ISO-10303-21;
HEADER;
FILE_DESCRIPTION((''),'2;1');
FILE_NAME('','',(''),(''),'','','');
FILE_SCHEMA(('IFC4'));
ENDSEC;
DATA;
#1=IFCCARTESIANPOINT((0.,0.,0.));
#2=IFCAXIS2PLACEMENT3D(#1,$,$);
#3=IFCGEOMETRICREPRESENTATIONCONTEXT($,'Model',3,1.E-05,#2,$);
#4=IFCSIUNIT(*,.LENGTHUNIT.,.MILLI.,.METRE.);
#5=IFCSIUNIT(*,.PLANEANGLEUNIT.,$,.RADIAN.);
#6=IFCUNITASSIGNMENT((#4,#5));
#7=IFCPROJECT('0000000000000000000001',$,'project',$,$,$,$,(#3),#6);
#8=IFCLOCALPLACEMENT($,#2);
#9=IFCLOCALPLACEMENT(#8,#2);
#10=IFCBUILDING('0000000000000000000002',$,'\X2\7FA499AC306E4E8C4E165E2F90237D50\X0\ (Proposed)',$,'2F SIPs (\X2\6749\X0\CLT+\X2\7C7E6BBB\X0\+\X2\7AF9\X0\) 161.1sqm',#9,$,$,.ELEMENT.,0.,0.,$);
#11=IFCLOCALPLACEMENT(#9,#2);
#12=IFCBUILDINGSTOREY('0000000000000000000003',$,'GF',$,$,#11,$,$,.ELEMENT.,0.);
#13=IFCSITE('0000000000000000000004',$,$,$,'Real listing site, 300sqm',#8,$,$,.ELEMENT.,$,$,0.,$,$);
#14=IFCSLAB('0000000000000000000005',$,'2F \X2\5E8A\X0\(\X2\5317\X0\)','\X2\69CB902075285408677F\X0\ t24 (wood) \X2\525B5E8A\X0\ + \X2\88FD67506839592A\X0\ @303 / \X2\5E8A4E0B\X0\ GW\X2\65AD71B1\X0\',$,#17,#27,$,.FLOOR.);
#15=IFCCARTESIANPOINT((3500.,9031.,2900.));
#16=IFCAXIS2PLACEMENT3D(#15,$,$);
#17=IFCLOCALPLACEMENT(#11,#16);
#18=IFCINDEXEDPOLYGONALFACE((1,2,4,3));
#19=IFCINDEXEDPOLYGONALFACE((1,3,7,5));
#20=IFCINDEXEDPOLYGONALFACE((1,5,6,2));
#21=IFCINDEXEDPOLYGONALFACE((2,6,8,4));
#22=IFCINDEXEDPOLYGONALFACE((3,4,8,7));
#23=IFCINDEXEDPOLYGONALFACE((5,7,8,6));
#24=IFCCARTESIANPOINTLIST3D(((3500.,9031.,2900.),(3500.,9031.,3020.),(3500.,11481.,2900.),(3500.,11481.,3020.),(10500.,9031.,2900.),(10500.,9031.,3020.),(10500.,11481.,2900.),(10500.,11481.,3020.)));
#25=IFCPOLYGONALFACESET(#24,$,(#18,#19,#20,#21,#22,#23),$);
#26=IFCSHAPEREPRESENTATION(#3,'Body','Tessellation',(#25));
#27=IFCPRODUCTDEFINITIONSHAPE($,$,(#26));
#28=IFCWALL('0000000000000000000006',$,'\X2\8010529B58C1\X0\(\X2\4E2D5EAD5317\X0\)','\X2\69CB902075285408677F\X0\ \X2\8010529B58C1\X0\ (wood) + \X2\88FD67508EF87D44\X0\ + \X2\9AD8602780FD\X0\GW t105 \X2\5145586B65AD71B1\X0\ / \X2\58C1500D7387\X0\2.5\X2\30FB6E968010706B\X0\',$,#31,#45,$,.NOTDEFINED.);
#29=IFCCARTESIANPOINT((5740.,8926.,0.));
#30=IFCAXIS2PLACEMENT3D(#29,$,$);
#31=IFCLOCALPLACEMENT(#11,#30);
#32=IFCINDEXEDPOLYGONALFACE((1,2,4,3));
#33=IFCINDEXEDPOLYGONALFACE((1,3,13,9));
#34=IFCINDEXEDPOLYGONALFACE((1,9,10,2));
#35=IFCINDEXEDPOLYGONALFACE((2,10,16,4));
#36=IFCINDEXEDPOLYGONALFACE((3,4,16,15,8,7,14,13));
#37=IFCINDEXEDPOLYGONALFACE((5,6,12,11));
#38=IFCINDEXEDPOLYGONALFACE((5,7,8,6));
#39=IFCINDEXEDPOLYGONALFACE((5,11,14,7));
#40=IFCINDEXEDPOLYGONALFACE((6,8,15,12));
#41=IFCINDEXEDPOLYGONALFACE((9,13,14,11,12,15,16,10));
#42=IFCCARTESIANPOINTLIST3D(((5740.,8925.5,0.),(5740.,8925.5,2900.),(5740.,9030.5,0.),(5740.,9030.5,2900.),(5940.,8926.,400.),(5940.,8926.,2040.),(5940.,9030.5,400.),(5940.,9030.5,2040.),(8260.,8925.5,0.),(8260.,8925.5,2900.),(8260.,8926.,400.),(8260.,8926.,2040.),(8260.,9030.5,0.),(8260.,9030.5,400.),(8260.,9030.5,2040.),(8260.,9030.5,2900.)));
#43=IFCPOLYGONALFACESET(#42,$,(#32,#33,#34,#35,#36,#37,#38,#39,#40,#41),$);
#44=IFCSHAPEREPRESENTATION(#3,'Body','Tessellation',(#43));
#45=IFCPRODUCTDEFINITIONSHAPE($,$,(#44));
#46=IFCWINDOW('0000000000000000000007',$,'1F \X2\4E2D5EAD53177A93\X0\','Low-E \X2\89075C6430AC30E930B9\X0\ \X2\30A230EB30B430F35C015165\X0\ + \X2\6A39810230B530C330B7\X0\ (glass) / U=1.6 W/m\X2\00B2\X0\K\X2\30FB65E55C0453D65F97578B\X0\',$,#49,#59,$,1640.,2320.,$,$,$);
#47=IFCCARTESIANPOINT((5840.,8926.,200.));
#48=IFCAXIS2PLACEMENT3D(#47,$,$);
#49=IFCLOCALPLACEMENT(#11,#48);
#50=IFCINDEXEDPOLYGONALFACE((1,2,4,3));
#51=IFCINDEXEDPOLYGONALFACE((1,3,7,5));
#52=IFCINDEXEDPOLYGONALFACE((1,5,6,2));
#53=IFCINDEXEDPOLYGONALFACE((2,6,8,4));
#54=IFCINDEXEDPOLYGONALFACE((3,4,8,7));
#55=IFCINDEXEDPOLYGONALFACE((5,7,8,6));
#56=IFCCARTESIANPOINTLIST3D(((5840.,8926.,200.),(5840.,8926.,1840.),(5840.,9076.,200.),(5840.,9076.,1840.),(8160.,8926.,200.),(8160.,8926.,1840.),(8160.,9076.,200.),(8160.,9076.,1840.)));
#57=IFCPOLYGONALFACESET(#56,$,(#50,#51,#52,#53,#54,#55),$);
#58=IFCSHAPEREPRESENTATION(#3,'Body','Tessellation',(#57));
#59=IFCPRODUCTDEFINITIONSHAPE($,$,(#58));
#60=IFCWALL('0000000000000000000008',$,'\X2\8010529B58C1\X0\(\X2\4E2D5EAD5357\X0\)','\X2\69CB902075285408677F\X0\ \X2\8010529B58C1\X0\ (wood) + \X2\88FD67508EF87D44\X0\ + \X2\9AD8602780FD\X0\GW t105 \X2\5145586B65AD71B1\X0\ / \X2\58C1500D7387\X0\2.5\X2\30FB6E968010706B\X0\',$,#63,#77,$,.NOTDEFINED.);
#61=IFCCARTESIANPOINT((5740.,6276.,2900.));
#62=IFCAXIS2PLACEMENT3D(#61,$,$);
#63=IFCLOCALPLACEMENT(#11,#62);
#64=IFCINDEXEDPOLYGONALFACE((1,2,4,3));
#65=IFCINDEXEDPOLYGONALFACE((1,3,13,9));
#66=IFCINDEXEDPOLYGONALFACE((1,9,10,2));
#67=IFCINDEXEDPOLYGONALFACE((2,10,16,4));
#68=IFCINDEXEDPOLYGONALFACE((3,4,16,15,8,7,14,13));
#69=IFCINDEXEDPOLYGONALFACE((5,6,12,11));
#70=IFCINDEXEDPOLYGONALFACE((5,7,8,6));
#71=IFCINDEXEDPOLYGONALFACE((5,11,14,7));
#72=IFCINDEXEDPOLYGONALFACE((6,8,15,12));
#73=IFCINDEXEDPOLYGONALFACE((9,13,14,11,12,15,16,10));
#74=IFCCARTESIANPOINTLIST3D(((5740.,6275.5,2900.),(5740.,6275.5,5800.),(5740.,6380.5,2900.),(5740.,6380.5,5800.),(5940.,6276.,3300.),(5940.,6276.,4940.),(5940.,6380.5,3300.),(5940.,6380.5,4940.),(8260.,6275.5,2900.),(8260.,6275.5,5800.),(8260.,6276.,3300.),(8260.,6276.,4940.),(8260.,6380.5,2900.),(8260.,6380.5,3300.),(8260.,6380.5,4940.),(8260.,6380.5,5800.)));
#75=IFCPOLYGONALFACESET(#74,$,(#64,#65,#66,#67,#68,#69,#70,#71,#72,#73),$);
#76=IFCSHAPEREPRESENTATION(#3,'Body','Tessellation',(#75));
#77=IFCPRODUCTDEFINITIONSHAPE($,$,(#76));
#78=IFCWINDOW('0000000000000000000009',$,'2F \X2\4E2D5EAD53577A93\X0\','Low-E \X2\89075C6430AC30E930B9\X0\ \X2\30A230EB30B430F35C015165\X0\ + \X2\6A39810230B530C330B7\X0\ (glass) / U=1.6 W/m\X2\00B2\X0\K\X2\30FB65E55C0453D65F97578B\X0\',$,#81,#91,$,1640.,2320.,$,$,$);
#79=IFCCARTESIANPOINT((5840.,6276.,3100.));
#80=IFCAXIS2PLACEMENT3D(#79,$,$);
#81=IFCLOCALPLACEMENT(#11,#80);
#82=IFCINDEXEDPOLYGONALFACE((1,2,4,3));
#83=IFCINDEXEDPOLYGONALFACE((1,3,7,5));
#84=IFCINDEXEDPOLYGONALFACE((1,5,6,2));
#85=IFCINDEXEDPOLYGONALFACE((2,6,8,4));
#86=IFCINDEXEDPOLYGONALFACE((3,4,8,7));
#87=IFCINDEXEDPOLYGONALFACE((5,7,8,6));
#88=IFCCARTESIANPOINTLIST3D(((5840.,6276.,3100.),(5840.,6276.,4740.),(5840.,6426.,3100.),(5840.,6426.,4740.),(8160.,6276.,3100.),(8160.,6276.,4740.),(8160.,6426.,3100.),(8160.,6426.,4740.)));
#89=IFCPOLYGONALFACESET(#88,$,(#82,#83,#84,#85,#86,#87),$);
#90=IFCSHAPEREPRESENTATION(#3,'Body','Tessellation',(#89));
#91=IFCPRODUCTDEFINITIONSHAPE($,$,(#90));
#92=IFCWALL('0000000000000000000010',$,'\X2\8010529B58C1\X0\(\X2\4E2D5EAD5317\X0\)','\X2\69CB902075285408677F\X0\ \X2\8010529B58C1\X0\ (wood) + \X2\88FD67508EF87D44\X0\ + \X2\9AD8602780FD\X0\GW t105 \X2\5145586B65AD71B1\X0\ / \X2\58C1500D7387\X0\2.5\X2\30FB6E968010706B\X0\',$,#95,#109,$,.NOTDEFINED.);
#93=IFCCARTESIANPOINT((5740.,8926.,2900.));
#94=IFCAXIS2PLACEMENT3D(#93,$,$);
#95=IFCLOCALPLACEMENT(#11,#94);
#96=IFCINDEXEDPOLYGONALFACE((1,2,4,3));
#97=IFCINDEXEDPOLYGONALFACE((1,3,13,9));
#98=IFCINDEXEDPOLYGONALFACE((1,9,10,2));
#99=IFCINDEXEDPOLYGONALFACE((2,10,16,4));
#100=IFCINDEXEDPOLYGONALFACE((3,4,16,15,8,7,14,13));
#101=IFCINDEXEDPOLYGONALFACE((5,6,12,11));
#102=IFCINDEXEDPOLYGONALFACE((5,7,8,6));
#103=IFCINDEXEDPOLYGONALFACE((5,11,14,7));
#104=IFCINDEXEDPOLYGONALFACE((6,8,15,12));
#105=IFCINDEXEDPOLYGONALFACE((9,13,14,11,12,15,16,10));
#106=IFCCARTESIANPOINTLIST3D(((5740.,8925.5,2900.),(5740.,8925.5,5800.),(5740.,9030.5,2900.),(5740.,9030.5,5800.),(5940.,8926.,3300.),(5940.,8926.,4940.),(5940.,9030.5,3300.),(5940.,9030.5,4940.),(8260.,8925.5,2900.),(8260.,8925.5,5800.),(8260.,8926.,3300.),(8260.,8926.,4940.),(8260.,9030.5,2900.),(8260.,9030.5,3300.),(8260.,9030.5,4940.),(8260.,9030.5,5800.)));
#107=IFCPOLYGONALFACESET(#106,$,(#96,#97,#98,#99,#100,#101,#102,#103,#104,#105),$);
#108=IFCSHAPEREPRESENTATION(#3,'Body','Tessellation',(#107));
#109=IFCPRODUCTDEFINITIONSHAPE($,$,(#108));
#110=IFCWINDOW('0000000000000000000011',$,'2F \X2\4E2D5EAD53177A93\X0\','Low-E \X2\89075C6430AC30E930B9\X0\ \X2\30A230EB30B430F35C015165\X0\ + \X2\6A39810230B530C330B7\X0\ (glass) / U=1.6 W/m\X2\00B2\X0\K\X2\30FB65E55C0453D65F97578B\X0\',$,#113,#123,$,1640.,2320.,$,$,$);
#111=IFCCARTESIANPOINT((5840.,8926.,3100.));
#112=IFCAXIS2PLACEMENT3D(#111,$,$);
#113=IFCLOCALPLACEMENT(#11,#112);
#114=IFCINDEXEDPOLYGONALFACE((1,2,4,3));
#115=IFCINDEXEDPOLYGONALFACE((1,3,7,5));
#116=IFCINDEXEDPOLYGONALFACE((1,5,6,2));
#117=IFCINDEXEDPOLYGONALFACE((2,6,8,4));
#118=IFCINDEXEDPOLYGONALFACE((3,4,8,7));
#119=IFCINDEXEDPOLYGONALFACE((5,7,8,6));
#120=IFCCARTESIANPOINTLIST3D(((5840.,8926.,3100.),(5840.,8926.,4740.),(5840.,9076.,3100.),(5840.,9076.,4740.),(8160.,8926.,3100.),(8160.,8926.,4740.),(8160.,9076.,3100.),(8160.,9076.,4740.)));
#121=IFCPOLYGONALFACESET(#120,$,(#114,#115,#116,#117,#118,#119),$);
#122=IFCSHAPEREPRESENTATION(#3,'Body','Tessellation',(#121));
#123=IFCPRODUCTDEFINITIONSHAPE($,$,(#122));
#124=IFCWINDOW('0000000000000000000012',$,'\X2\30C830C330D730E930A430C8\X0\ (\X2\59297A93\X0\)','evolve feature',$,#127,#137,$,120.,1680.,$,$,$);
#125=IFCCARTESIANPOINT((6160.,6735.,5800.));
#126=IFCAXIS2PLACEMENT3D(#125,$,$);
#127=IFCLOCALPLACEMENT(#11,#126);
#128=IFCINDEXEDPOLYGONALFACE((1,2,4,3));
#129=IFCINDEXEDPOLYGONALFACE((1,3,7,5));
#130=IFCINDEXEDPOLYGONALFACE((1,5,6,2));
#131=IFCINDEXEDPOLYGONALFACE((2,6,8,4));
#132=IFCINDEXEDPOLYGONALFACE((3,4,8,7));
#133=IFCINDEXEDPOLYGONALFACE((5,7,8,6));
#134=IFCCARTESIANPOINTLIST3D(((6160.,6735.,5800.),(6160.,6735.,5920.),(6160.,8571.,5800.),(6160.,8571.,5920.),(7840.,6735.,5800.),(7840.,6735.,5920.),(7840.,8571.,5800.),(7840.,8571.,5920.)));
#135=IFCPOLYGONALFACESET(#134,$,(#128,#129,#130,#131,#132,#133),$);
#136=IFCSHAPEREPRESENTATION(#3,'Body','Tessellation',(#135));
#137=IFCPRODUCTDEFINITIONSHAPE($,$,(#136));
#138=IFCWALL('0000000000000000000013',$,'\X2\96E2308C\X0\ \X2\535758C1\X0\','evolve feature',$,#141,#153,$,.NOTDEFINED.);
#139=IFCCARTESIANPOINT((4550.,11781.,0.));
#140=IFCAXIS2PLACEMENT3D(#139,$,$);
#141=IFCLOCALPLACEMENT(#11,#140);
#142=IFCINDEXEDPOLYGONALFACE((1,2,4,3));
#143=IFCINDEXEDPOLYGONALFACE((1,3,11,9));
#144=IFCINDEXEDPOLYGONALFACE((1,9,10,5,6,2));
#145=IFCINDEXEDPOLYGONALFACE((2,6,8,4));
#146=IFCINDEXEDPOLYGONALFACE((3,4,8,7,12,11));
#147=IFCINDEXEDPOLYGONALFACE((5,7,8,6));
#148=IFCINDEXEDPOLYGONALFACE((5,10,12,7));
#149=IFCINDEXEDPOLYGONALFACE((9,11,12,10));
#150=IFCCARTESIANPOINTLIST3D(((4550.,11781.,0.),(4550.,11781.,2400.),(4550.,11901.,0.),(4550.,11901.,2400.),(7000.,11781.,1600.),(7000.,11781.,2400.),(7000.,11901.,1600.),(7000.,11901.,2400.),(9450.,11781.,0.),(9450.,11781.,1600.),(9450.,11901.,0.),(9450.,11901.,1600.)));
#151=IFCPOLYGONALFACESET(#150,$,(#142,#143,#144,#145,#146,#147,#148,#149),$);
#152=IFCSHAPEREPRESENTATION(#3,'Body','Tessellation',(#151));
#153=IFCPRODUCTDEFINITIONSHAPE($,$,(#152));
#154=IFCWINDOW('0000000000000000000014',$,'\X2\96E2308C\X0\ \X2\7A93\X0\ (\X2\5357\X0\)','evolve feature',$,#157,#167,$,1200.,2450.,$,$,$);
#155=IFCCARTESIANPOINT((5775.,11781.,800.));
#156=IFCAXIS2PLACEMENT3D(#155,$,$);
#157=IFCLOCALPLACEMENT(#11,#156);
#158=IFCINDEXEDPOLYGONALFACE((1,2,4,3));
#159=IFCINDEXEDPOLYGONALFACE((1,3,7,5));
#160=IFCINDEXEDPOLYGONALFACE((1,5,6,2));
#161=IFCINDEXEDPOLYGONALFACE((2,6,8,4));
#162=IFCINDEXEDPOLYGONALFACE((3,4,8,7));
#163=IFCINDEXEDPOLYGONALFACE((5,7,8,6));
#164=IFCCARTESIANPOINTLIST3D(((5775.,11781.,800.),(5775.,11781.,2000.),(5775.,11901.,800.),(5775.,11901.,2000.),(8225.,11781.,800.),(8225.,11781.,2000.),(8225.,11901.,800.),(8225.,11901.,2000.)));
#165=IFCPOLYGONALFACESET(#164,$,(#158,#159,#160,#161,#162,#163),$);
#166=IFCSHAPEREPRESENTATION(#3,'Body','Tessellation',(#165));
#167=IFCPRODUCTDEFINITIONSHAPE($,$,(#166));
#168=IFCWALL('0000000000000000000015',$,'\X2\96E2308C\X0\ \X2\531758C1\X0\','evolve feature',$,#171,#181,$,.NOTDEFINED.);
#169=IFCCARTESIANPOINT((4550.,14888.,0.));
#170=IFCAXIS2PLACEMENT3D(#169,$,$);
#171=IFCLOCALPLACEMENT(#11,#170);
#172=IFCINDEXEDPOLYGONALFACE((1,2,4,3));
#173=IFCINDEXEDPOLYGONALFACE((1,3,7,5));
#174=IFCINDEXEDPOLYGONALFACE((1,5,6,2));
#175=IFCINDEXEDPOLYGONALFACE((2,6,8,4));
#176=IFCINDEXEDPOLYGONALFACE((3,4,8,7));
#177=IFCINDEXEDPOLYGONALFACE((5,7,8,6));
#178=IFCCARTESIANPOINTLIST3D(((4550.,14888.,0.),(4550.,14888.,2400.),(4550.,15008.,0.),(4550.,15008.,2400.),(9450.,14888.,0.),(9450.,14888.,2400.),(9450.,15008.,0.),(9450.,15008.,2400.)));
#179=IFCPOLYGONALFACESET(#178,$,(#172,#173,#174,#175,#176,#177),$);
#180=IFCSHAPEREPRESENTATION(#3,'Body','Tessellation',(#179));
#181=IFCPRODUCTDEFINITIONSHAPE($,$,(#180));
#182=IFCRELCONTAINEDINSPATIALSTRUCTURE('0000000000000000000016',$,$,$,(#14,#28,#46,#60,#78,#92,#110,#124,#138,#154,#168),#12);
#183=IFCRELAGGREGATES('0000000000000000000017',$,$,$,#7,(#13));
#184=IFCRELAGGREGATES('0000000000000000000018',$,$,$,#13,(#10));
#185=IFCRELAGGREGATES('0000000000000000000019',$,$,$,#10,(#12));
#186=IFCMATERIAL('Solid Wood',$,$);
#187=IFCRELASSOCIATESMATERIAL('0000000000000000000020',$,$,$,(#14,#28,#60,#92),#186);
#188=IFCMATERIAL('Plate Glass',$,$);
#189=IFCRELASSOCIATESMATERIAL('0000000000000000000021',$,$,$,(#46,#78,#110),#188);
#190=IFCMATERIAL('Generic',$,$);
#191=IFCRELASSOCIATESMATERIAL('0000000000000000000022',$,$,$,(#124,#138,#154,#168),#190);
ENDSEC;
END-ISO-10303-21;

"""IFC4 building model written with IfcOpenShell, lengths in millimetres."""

from ifc_helpers import new_model, si_unit, frame, frame_2d, origin, place, context, project, spatial, rectangle, extrude, material, element, fill, save


model = new_model("IFC4")

# Units and contexts
model_context = context("Model", 3, precision=1e-05, world=origin())
ifc_project = project(units=[si_unit("LENGTHUNIT", "METRE", prefix="MILLI"), si_unit("PLANEANGLEUNIT", "RADIAN")], contexts=[model_context])

# Site, building, storey
site_placement = place(None, origin())
site = spatial("IfcSite", under=ifc_project, at=site_placement, ObjectType="Real listing site, 300sqm", CompositionType="ELEMENT", RefElevation=0.0)
building_placement = place(site_placement, origin())
building = spatial("IfcBuilding", under=site, at=building_placement, Name="群馬の二世帯連結 (Proposed)", ObjectType="2F SIPs (杉CLT+籾殻+竹) 161.1sqm", CompositionType="ELEMENT", ElevationOfRefHeight=0.0, ElevationOfTerrain=0.0)
storey_placement = place(building_placement, origin())
storey = spatial("IfcBuildingStorey", under=building, at=storey_placement, Name="GF", CompositionType="ELEMENT", Elevation=0.0)

# Slab
ifc_material_1 = material(Name="Solid Wood")
slab_1_placement = place(storey_placement, frame((3500.0, 9031.0, 2900.0)))
element("IfcSlab", 1, at=slab_1_placement, inside=storey, material=ifc_material_1, Name="2F 床(北)", Description="構造用合板 t24 (wood) 剛床 + 製材根太 @303 / 床下 GW断熱", PredefinedType="FLOOR", context=model_context, shape_type="SweptSolid", body=[
    extrude(rectangle(XDim=7000.0, YDim=2450.0, at=frame_2d((3500.0, 1225.0))), frame((3500.0, 9031.0, 2900.0)), (0.0, 0.0, 1.0), 120.0),
])
ifc_material_2 = material(Name="Generic")

# Wall, opening, window
wall_1_placement = place(storey_placement, frame((5740.0, 8926.0, 0.0)))
wall_1 = element("IfcWall", 2, at=wall_1_placement, inside=storey, material=ifc_material_1, Name="耐力壁(中庭北)", Description="構造用合板 耐力壁 (wood) + 製材軸組 + 高性能GW t105 充填断熱 / 壁倍率2.5・準耐火", PredefinedType="NOTDEFINED", context=model_context, shape_type="SweptSolid", body=[
    extrude(rectangle(XDim=2520.0, YDim=105.0, at=frame_2d((1260.0, 52.0))), frame((5740.0, 8926.0, 0.0)), (0.0, 0.0, 1.0), 2900.0),
])
opening_1_placement = place(storey_placement, frame((5840.0, 8926.0, 200.0)))
opening_1 = element("IfcOpeningElement", 3, at=opening_1_placement, cuts=wall_1, PredefinedType="NOTDEFINED", context=model_context, shape_type="SweptSolid", body=[
    extrude(rectangle(XDim=2320.0, YDim=150.0, at=frame_2d((1160.0, 75.0))), frame((5840.0, 8926.0, 200.0)), (0.0, 0.0, 1.0), 1640.0),
])
ifc_material_3 = material(Name="Plate Glass")
window_1_placement = place(storey_placement, frame((5840.0, 8926.0, 200.0)))
window_1 = element("IfcWindow", 4, at=window_1_placement, inside=storey, material=ifc_material_3, Name="1F 中庭北窓", Description="Low-E 複層ガラス アルゴン封入 + 樹脂サッシ (glass) / U=1.6 W/m²K・日射取得型", OverallHeight=1640.0, OverallWidth=2320.0, context=model_context, shape_type="SweptSolid", body=[
    extrude(rectangle(XDim=2320.0, YDim=150.0, at=frame_2d((1160.0, 75.0))), frame((5840.0, 8926.0, 200.0)), (0.0, 0.0, 1.0), 1640.0),
])
fill(opening_1, window_1)

# Walls, openings, windows
wall_2_placement = place(storey_placement, frame((5740.0, 6276.0, 2900.0)))
wall_2 = element("IfcWall", 5, at=wall_2_placement, inside=storey, material=ifc_material_1, Name="耐力壁(中庭南)", Description="構造用合板 耐力壁 (wood) + 製材軸組 + 高性能GW t105 充填断熱 / 壁倍率2.5・準耐火", PredefinedType="NOTDEFINED", context=model_context, shape_type="SweptSolid", body=[
    extrude(rectangle(XDim=2520.0, YDim=105.0, at=frame_2d((1260.0, 52.0))), frame((5740.0, 6276.0, 2900.0)), (0.0, 0.0, 1.0), 2900.0),
])
opening_2_placement = place(storey_placement, frame((5840.0, 6276.0, 3100.0)))
opening_2 = element("IfcOpeningElement", 6, at=opening_2_placement, cuts=wall_2, PredefinedType="NOTDEFINED", context=model_context, shape_type="SweptSolid", body=[
    extrude(rectangle(XDim=2320.0, YDim=150.0, at=frame_2d((1160.0, 75.0))), frame((5840.0, 6276.0, 3100.0)), (0.0, 0.0, 1.0), 1640.0),
])
window_2_placement = place(storey_placement, frame((5840.0, 6276.0, 3100.0)))
window_2 = element("IfcWindow", 7, at=window_2_placement, inside=storey, material=ifc_material_3, Name="2F 中庭南窓", Description="Low-E 複層ガラス アルゴン封入 + 樹脂サッシ (glass) / U=1.6 W/m²K・日射取得型", OverallHeight=1640.0, OverallWidth=2320.0, context=model_context, shape_type="SweptSolid", body=[
    extrude(rectangle(XDim=2320.0, YDim=150.0, at=frame_2d((1160.0, 75.0))), frame((5840.0, 6276.0, 3100.0)), (0.0, 0.0, 1.0), 1640.0),
])
fill(opening_2, window_2)
wall_3_placement = place(storey_placement, frame((5740.0, 8926.0, 2900.0)))
wall_3 = element("IfcWall", 8, at=wall_3_placement, inside=storey, material=ifc_material_1, Name="耐力壁(中庭北)", Description="構造用合板 耐力壁 (wood) + 製材軸組 + 高性能GW t105 充填断熱 / 壁倍率2.5・準耐火", PredefinedType="NOTDEFINED", context=model_context, shape_type="SweptSolid", body=[
    extrude(rectangle(XDim=2520.0, YDim=105.0, at=frame_2d((1260.0, 52.0))), frame((5740.0, 8926.0, 2900.0)), (0.0, 0.0, 1.0), 2900.0),
])
opening_3_placement = place(storey_placement, frame((5840.0, 8926.0, 3100.0)))
opening_3 = element("IfcOpeningElement", 9, at=opening_3_placement, cuts=wall_3, PredefinedType="NOTDEFINED", context=model_context, shape_type="SweptSolid", body=[
    extrude(rectangle(XDim=2320.0, YDim=150.0, at=frame_2d((1160.0, 75.0))), frame((5840.0, 8926.0, 3100.0)), (0.0, 0.0, 1.0), 1640.0),
])
window_3_placement = place(storey_placement, frame((5840.0, 8926.0, 3100.0)))
window_3 = element("IfcWindow", 10, at=window_3_placement, inside=storey, material=ifc_material_3, Name="2F 中庭北窓", Description="Low-E 複層ガラス アルゴン封入 + 樹脂サッシ (glass) / U=1.6 W/m²K・日射取得型", OverallHeight=1640.0, OverallWidth=2320.0, context=model_context, shape_type="SweptSolid", body=[
    extrude(rectangle(XDim=2320.0, YDim=150.0, at=frame_2d((1160.0, 75.0))), frame((5840.0, 8926.0, 3100.0)), (0.0, 0.0, 1.0), 1640.0),
])
fill(opening_3, window_3)

# Window
window_4_placement = place(storey_placement, frame((6160.0, 6735.0, 5800.0)))
element("IfcWindow", 11, at=window_4_placement, inside=storey, material=ifc_material_2, Name="トップライト (天窓)", Description="evolve feature", OverallHeight=120.0, OverallWidth=1680.0, context=model_context, shape_type="SweptSolid", body=[
    extrude(rectangle(XDim=1680.0, YDim=1836.0, at=frame_2d((840.0, 918.0))), frame((6160.0, 6735.0, 5800.0)), (0.0, 0.0, 1.0), 120.0),
])

# Wall, opening, window
wall_4_placement = place(storey_placement, frame((4550.0, 11781.0, 0.0)))
wall_4 = element("IfcWall", 12, at=wall_4_placement, inside=storey, material=ifc_material_2, Name="離れ 南壁", Description="evolve feature", PredefinedType="NOTDEFINED", context=model_context, shape_type="SweptSolid", body=[
    extrude(rectangle(XDim=4900.0, YDim=120.0, at=frame_2d((2450.0, 60.0))), frame((4550.0, 11781.0, 0.0)), (0.0, 0.0, 1.0), 2400.0),
])
opening_4_placement = place(storey_placement, frame((5775.0, 11781.0, 800.0)))
opening_4 = element("IfcOpeningElement", 13, at=opening_4_placement, cuts=wall_4, PredefinedType="NOTDEFINED", context=model_context, shape_type="SweptSolid", body=[
    extrude(rectangle(XDim=2450.0, YDim=120.0, at=frame_2d((1225.0, 60.0))), frame((5775.0, 11781.0, 800.0)), (0.0, 0.0, 1.0), 1200.0),
])
window_5_placement = place(storey_placement, frame((5775.0, 11781.0, 800.0)))
window_5 = element("IfcWindow", 14, at=window_5_placement, inside=storey, material=ifc_material_2, Name="離れ 窓 (南)", Description="evolve feature", OverallHeight=1200.0, OverallWidth=2450.0, context=model_context, shape_type="SweptSolid", body=[
    extrude(rectangle(XDim=2450.0, YDim=120.0, at=frame_2d((1225.0, 60.0))), frame((5775.0, 11781.0, 800.0)), (0.0, 0.0, 1.0), 1200.0),
])
fill(opening_4, window_5)

# Wall
wall_5_placement = place(storey_placement, frame((4550.0, 14888.0, 0.0)))
element("IfcWall", 15, at=wall_5_placement, inside=storey, material=ifc_material_2, Name="離れ 北壁", Description="evolve feature", PredefinedType="NOTDEFINED", context=model_context, shape_type="SweptSolid", body=[
    extrude(rectangle(XDim=4900.0, YDim=120.0, at=frame_2d((2450.0, 60.0))), frame((4550.0, 14888.0, 0.0)), (0.0, 0.0, 1.0), 2400.0),
])

save(model, "model.ifc")
